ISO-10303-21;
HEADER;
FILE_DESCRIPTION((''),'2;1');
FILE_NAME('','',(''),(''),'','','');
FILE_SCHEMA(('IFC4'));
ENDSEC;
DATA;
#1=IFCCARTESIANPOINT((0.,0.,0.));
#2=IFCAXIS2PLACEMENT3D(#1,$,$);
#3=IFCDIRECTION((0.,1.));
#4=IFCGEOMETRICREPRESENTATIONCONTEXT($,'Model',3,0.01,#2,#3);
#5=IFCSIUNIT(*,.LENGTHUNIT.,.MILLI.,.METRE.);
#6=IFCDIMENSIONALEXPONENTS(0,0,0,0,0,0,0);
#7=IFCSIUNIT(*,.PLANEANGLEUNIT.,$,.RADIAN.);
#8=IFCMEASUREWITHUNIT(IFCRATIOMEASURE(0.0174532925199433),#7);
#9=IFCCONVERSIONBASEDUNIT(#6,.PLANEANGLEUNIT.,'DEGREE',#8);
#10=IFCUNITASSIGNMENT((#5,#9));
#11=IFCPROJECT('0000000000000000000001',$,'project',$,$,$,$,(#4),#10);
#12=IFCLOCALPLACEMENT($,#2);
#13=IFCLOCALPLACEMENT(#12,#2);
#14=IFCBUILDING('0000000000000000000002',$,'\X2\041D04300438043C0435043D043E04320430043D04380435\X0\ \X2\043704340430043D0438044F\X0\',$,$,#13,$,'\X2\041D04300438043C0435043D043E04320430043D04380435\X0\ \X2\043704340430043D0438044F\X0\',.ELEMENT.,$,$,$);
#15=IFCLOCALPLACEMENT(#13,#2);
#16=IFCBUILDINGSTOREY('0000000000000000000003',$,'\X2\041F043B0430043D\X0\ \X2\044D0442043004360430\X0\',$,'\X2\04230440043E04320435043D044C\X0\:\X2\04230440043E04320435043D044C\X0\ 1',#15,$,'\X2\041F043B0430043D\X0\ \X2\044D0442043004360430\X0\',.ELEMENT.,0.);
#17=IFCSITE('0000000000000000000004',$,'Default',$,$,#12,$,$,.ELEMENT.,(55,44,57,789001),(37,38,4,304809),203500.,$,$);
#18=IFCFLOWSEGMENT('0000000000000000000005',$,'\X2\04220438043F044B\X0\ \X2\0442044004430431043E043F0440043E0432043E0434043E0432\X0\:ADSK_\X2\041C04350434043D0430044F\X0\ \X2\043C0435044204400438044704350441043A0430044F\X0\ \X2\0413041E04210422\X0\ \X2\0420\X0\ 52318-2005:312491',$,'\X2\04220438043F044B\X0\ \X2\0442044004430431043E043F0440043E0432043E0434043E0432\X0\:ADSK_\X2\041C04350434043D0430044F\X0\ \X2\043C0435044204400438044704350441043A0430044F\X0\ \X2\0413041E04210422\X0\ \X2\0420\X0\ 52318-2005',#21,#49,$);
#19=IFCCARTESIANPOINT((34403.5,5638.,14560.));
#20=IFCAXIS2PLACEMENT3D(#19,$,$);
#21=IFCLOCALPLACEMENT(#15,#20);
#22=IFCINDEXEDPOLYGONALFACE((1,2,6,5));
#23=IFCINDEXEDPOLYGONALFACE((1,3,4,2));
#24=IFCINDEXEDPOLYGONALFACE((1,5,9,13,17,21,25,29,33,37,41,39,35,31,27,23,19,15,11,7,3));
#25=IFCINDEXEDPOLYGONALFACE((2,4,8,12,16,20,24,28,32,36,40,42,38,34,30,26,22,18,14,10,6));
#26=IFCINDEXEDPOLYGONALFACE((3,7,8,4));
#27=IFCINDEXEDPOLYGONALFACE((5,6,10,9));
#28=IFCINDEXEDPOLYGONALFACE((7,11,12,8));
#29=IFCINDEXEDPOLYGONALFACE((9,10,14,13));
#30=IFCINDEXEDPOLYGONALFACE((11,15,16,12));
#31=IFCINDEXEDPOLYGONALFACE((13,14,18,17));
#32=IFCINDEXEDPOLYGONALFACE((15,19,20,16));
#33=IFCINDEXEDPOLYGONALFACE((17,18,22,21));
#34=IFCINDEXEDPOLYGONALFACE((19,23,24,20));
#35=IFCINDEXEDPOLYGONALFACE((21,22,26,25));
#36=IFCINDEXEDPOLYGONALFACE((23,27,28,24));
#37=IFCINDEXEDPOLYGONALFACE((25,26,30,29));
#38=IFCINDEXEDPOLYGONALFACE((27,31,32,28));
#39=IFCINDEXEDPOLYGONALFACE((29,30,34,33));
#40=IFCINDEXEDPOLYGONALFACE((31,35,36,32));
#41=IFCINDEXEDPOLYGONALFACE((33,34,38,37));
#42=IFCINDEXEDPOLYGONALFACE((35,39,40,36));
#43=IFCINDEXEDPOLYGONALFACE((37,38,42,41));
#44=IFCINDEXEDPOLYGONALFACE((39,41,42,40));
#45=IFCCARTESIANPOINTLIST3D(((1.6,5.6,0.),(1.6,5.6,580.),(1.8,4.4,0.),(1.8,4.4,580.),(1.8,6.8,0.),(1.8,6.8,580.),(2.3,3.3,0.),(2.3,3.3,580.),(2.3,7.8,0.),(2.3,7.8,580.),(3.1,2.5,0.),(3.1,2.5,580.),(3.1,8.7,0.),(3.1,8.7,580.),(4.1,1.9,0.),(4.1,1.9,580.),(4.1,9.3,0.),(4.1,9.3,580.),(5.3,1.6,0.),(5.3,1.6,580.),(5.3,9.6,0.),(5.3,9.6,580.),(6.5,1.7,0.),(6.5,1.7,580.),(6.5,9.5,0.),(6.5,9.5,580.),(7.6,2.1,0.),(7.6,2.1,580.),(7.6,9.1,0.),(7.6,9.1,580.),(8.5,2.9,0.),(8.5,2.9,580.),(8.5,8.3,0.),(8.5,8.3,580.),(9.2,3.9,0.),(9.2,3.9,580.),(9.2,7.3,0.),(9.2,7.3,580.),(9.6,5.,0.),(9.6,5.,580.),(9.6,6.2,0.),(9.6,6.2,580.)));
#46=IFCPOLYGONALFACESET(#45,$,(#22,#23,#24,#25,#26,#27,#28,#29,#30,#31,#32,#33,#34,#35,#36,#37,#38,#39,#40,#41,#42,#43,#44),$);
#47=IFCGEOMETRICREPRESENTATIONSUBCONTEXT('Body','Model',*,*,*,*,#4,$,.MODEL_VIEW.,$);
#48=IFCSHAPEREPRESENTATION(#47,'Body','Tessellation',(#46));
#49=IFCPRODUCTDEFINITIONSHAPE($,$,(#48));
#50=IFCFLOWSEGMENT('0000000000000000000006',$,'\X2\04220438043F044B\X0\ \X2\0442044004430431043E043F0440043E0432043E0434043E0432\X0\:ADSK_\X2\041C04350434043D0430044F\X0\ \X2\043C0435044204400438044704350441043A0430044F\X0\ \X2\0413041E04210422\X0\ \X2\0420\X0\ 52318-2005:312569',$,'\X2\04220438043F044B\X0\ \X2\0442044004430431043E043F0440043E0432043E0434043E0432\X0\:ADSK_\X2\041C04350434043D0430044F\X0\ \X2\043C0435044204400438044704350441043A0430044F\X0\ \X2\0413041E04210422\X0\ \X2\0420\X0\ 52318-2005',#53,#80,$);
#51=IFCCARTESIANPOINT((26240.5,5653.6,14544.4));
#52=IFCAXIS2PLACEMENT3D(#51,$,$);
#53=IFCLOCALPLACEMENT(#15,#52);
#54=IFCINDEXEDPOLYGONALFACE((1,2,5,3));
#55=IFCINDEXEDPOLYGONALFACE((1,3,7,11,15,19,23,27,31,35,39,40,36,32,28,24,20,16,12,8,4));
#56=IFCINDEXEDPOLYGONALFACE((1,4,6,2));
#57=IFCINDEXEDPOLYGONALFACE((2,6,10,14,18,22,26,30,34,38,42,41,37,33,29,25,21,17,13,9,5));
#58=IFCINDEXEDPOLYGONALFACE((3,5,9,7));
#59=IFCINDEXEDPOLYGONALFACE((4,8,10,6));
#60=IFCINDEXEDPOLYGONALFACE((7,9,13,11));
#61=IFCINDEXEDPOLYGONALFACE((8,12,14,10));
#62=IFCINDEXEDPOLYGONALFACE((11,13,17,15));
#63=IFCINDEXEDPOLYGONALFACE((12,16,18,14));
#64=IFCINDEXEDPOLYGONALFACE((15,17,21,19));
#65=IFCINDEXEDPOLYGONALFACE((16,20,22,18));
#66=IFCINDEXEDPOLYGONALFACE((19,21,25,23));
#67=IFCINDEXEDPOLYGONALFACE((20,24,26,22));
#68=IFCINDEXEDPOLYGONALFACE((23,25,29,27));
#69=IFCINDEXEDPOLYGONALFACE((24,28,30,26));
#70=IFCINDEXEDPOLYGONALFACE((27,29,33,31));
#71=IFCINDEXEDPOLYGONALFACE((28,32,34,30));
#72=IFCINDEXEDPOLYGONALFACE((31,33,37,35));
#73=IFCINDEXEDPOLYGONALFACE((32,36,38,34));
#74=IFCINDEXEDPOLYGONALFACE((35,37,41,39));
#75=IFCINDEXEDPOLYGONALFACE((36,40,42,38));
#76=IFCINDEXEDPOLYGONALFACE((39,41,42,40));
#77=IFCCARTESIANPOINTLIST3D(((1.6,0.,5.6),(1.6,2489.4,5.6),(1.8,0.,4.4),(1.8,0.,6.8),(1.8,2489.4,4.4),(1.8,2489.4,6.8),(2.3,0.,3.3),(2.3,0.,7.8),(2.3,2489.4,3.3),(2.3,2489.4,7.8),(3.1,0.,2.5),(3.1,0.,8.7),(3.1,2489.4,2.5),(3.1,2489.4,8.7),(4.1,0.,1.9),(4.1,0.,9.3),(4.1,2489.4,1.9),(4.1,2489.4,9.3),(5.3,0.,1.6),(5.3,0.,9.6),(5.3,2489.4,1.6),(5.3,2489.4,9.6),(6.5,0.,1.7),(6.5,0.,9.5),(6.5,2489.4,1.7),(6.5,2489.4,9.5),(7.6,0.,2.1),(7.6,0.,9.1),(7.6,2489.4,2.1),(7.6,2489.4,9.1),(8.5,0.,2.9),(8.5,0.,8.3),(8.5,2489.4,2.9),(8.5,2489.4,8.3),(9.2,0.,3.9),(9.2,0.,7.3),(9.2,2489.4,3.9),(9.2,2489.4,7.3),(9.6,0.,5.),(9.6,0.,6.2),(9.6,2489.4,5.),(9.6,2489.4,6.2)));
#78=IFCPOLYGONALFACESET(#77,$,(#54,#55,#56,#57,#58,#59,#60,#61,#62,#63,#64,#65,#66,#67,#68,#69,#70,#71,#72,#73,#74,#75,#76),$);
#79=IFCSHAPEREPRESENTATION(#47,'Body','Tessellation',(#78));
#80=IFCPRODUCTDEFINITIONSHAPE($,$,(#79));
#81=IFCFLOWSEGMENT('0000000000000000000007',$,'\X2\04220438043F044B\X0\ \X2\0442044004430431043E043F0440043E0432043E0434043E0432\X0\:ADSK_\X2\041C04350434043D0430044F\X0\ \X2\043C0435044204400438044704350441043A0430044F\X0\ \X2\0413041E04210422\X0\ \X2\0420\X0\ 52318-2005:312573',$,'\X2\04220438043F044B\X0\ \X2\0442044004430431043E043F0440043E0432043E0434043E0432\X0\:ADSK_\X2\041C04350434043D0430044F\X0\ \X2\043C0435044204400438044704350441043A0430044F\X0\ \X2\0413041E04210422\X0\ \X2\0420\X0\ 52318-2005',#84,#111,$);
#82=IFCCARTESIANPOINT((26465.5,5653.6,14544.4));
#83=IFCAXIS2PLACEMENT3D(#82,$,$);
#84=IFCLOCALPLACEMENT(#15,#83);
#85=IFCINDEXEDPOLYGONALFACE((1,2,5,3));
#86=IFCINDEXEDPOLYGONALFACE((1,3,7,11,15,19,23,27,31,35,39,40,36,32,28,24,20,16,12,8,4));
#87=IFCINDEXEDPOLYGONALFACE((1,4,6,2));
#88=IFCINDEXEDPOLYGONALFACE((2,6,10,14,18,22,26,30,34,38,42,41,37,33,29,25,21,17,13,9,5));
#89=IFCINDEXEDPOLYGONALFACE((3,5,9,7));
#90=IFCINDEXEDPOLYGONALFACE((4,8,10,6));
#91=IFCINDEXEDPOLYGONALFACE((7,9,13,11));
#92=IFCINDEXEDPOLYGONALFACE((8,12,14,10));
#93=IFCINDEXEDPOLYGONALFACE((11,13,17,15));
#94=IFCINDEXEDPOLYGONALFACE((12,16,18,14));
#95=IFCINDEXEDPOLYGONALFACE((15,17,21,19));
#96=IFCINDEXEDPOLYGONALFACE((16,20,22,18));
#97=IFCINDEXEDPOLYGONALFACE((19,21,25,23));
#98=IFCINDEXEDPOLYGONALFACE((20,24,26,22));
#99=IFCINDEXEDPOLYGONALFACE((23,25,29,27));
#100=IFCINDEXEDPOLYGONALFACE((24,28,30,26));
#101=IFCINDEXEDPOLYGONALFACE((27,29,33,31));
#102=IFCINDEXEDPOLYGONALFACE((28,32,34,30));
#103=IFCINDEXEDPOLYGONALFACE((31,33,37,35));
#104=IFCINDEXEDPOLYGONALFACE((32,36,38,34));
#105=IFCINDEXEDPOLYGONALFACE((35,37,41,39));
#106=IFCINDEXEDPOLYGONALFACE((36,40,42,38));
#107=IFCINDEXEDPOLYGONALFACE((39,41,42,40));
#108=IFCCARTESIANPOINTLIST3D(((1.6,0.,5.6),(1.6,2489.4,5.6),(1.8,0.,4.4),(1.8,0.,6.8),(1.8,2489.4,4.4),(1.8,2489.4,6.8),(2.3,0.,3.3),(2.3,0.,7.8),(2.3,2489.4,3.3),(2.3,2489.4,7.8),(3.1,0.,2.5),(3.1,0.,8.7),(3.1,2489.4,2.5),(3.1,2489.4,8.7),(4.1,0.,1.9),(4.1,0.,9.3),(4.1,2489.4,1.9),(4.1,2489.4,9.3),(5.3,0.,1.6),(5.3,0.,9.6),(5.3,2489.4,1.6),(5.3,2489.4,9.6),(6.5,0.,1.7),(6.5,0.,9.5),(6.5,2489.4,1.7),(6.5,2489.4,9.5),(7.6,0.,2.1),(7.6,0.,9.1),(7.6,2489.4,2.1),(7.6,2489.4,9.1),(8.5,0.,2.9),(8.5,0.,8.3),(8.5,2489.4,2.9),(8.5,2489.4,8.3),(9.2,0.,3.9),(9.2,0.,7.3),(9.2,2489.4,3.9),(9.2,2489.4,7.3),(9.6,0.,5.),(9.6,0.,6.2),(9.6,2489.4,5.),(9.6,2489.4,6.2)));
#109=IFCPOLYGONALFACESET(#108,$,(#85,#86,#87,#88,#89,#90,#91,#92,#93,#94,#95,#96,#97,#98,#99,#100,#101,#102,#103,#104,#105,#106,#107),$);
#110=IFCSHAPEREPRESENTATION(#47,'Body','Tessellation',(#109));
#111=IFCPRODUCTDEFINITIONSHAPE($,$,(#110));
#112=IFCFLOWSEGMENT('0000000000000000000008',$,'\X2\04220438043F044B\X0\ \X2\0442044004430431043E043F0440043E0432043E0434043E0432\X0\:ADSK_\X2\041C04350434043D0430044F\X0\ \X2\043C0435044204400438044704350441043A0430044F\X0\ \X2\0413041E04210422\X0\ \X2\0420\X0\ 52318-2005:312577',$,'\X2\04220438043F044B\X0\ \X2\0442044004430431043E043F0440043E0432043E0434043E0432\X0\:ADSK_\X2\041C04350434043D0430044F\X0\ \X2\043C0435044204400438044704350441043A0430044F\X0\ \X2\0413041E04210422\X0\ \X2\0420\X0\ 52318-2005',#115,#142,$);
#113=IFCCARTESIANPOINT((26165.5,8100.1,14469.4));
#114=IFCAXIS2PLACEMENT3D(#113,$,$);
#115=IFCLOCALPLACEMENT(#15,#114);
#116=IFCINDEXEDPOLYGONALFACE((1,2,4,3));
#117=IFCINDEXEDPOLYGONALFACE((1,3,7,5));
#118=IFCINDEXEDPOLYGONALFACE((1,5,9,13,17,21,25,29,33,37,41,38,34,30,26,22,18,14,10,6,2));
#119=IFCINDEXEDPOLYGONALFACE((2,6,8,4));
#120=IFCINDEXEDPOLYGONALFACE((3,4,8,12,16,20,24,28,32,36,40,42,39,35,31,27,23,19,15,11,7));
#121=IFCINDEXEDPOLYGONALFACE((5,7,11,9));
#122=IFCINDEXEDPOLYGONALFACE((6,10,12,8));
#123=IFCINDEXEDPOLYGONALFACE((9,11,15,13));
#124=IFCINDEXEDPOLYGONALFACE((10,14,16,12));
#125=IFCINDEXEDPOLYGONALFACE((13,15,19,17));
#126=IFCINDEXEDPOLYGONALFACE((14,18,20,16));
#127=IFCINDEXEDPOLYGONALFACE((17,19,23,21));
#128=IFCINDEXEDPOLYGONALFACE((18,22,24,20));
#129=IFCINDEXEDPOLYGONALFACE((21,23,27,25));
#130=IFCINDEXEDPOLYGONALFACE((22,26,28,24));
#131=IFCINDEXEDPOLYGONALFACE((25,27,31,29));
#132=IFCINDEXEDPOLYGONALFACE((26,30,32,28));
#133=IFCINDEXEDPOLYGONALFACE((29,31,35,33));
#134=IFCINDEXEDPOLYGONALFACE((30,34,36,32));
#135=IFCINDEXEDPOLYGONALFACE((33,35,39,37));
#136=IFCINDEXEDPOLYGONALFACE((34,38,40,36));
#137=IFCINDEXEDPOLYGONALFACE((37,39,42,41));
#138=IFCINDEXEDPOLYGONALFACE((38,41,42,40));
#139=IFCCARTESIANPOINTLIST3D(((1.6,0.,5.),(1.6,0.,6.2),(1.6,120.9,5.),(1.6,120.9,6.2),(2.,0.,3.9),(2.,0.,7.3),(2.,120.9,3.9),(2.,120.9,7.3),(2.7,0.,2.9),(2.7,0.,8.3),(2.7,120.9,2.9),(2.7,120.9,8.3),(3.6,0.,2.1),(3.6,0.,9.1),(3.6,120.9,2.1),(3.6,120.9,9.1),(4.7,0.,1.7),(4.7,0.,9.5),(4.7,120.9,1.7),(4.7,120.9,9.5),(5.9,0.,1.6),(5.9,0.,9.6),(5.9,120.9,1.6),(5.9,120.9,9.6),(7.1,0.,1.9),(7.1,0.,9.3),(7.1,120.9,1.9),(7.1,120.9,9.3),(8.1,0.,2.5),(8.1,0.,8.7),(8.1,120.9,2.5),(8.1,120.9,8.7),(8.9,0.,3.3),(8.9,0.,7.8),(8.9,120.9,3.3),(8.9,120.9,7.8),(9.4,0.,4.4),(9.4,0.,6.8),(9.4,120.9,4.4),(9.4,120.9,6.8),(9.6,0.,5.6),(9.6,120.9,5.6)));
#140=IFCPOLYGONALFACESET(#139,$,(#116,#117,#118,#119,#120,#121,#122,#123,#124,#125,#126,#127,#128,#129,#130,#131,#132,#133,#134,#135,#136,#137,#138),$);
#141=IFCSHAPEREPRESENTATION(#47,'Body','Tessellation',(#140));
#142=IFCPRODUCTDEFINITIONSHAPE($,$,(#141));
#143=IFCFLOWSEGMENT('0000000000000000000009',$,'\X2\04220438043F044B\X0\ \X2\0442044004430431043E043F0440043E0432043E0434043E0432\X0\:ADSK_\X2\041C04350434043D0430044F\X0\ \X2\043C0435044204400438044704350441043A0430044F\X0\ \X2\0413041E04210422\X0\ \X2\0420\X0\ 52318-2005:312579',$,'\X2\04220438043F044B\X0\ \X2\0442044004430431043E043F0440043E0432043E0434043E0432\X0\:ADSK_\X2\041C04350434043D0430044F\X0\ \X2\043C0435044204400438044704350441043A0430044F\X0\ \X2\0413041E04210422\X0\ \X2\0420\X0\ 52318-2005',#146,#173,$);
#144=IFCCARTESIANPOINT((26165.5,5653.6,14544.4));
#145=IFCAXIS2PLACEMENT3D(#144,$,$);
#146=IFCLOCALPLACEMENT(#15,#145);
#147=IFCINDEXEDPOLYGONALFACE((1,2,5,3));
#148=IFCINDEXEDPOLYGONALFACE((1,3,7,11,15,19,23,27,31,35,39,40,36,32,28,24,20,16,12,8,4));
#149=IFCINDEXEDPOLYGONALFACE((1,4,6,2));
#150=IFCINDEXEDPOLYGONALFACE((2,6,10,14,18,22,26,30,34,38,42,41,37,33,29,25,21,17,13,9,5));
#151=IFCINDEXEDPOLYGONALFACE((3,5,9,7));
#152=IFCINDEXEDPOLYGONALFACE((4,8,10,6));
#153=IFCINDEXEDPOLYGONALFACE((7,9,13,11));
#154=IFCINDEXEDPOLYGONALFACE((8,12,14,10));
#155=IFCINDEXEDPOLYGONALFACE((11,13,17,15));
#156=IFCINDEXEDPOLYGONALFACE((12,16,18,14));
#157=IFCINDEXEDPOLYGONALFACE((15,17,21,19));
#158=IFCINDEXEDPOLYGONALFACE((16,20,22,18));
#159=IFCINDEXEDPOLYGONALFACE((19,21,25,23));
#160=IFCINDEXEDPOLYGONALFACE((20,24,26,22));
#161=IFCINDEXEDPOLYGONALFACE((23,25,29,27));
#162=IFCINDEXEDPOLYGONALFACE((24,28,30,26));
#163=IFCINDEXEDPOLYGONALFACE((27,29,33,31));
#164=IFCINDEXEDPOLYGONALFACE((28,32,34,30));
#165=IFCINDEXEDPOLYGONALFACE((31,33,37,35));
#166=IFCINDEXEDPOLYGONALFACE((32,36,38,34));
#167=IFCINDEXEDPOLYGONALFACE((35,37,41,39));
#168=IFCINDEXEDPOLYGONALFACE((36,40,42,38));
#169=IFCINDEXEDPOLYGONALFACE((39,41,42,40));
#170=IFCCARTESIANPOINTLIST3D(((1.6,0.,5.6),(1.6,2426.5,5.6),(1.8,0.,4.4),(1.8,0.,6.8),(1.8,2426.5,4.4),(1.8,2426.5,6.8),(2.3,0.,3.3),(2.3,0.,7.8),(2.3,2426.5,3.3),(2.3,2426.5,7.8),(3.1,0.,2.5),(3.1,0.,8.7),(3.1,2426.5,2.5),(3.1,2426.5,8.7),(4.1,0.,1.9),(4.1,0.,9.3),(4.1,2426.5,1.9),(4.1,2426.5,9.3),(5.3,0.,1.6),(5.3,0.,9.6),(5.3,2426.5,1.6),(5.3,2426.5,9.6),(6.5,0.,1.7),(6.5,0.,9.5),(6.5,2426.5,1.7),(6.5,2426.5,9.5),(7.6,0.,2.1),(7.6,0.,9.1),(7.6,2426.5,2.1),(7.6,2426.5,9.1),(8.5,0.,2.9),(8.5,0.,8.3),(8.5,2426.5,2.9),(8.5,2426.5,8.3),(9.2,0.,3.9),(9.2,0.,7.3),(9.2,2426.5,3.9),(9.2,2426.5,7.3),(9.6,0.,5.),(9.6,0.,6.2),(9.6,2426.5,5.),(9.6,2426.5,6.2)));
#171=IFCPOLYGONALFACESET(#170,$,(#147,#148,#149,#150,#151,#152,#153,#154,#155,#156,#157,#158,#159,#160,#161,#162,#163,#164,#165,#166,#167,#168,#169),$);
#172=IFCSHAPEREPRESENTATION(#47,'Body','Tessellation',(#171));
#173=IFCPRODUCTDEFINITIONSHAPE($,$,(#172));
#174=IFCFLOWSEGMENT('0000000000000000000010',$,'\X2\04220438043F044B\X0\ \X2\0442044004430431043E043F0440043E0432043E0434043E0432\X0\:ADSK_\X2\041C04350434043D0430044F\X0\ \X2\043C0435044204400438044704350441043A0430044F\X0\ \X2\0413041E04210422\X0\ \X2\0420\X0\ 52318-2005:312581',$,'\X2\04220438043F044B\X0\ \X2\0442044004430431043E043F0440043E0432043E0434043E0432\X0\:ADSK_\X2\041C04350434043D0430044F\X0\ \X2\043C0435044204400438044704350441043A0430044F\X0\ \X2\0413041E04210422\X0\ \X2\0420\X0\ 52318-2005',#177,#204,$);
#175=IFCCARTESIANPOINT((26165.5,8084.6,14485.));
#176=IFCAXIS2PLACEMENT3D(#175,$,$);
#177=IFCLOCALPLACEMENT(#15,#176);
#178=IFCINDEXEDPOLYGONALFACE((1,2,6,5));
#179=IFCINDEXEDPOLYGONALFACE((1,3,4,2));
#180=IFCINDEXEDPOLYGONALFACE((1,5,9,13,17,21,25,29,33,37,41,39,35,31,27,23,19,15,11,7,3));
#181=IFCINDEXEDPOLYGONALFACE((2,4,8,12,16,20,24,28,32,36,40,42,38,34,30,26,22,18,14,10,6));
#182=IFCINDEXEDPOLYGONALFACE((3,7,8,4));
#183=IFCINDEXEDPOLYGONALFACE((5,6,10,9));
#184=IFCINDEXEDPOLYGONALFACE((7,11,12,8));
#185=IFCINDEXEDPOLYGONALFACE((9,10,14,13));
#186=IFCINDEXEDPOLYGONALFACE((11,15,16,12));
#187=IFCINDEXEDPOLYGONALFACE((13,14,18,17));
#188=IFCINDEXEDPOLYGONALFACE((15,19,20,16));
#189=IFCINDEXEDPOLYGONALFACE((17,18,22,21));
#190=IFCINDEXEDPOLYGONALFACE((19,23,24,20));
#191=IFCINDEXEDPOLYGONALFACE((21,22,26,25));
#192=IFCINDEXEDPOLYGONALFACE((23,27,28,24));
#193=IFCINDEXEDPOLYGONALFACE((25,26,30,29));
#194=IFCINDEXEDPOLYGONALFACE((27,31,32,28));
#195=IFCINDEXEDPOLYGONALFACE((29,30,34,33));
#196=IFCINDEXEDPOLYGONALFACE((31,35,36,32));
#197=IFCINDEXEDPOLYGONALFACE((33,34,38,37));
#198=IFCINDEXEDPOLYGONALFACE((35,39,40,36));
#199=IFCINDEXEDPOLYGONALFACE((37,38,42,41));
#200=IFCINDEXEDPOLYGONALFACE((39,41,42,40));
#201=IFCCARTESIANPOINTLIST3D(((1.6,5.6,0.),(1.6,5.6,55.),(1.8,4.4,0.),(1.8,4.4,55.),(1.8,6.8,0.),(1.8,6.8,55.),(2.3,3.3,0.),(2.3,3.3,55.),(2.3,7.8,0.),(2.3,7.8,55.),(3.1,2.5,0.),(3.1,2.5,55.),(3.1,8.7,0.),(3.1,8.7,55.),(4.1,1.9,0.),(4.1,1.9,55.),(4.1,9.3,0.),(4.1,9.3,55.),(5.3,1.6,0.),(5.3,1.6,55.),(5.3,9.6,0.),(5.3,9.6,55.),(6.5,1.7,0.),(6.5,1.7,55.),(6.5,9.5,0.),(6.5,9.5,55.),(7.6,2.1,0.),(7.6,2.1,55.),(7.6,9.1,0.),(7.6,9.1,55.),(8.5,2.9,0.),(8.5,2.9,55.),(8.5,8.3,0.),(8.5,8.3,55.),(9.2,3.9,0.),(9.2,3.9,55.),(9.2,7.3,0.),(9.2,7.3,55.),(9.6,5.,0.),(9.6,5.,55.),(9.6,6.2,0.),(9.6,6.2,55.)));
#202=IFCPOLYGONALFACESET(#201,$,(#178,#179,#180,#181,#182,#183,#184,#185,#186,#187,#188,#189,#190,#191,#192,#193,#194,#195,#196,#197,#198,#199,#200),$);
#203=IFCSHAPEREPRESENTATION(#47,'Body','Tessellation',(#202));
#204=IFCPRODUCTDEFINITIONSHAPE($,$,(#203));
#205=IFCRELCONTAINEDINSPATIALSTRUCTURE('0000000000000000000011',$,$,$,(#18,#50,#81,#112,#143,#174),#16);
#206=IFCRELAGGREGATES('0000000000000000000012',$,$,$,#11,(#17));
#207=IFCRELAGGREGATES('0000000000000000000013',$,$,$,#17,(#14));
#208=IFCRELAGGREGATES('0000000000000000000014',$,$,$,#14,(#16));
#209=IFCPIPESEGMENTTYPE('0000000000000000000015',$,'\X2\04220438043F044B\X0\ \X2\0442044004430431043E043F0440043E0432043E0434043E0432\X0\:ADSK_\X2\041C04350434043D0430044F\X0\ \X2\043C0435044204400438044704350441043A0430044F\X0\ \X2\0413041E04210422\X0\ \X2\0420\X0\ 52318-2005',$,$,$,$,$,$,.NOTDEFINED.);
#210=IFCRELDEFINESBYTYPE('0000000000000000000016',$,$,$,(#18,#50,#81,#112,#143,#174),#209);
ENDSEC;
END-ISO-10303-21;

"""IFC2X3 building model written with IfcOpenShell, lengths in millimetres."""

from ifc_helpers import new_model, entity, si_unit, converted_unit, direction, frame, frame_2d, origin, origin_2d_with_axis, place, context, subcontext, project, spatial, circle, extrude, type_object, element, save


model = new_model("IFC2X3")

# Units and contexts
model_context = context("Model", 3, precision=0.01, world=origin(), true_north=direction((0.0, 1.0)))
body_context = subcontext(model_context, "Body", "Model", "MODEL_VIEW")
ifc_project = project(units=[si_unit("LENGTHUNIT", "METRE", prefix="MILLI"), converted_unit("PLANEANGLEUNIT", "DEGREE", entity("IfcRatioMeasure", 0.0174532925199433), si_unit("PLANEANGLEUNIT", "RADIAN"), dimensions=[0, 0, 0, 0, 0, 0, 0])], contexts=[model_context])

# Site, building, storey
site_placement = place(None, frame((0.0, 0.0, 0.0)))
site = spatial("IfcSite", under=ifc_project, at=site_placement, Name="Default", CompositionType="ELEMENT", RefLatitude=(55, 44, 57, 789001), RefLongitude=(37, 38, 4, 304809), RefElevation=203500.0)
building_placement = place(site_placement, origin())
building = spatial("IfcBuilding", under=site, at=building_placement, Name="Наименование здания", LongName="Наименование здания", CompositionType="ELEMENT")
storey_placement = place(building_placement, origin())
storey = spatial("IfcBuildingStorey", under=building, at=storey_placement, Name="План этажа", ObjectType="Уровень:Уровень 1", LongName="План этажа", CompositionType="ELEMENT", Elevation=0.0)

# Flow segments
pipe_segment_type = type_object("IfcPipeSegmentType", Name="Типы трубопроводов:ADSK_Медная метрическая ГОСТ Р 52318-2005", PredefinedType="NOTDEFINED")
flow_segment_1_placement = place(storey_placement, frame((34403.5, 5638.0, 14560.0)))
element("IfcFlowSegment", 1, at=flow_segment_1_placement, inside=storey, type_object=pipe_segment_type, Name="Типы трубопроводов:ADSK_Медная метрическая ГОСТ Р 52318-2005:312491", ObjectType="Типы трубопроводов:ADSK_Медная метрическая ГОСТ Р 52318-2005", context=body_context, shape_type="SweptSolid", body=[
    extrude(circle(Radius=4.0, at=origin_2d_with_axis()), frame((5.6, 5.6, 0.0), z_axis=(0.0, 0.0, 1.0), x_axis=(-1.0, 0.0, 0.0)), (0.0, 0.0, 1.0), 580.0),
])
flow_segment_2_placement = place(storey_placement, frame((26240.5, 5653.6, 14544.4)))
element("IfcFlowSegment", 2, at=flow_segment_2_placement, inside=storey, type_object=pipe_segment_type, Name="Типы трубопроводов:ADSK_Медная метрическая ГОСТ Р 52318-2005:312569", ObjectType="Типы трубопроводов:ADSK_Медная метрическая ГОСТ Р 52318-2005", context=body_context, shape_type="SweptSolid", body=[
    extrude(circle(Radius=4.0, at=frame_2d((0.0, 0.0), x_axis=(1.0, 0.0))), frame((5.6, 0.0, 5.6), z_axis=(0.0, 1.0, 0.0), x_axis=(-1.0, 0.0, 0.0)), (0.0, 0.0, 1.0), 2489.4),
])
flow_segment_3_placement = place(storey_placement, frame((26465.5, 5653.6, 14544.4)))
element("IfcFlowSegment", 3, at=flow_segment_3_placement, inside=storey, type_object=pipe_segment_type, Name="Типы трубопроводов:ADSK_Медная метрическая ГОСТ Р 52318-2005:312573", ObjectType="Типы трубопроводов:ADSK_Медная метрическая ГОСТ Р 52318-2005", context=body_context, shape_type="SweptSolid", body=[
    extrude(circle(Radius=4.0, at=frame_2d((0.0, 0.0), x_axis=(1.0, 0.0))), frame((5.6, 0.0, 5.6), z_axis=(0.0, 1.0, 0.0), x_axis=(-1.0, 0.0, 0.0)), (0.0, 0.0, 1.0), 2489.4),
])
flow_segment_4_placement = place(storey_placement, frame((26165.5, 8100.1, 14469.4)))
element("IfcFlowSegment", 4, at=flow_segment_4_placement, inside=storey, type_object=pipe_segment_type, Name="Типы трубопроводов:ADSK_Медная метрическая ГОСТ Р 52318-2005:312577", ObjectType="Типы трубопроводов:ADSK_Медная метрическая ГОСТ Р 52318-2005", context=body_context, shape_type="SweptSolid", body=[
    extrude(circle(Radius=4.0, at=origin_2d_with_axis()), frame((5.6, 0.0, 5.6), z_axis=(0.0, 1.0, 0.0), x_axis=(1.0, 0.0, 0.0)), (0.0, 0.0, 1.0), 120.9),
])
flow_segment_5_placement = place(storey_placement, frame((26165.5, 5653.6, 14544.4)))
element("IfcFlowSegment", 5, at=flow_segment_5_placement, inside=storey, type_object=pipe_segment_type, Name="Типы трубопроводов:ADSK_Медная метрическая ГОСТ Р 52318-2005:312579", ObjectType="Типы трубопроводов:ADSK_Медная метрическая ГОСТ Р 52318-2005", context=body_context, shape_type="SweptSolid", body=[
    extrude(circle(Radius=4.0, at=origin_2d_with_axis()), frame((5.6, 0.0, 5.6), z_axis=(0.0, 1.0, 0.0), x_axis=(-1.0, 0.0, 0.0)), (0.0, 0.0, 1.0), 2426.5),
])
flow_segment_6_placement = place(storey_placement, frame((26165.5, 8084.6, 14485.0)))
element("IfcFlowSegment", 6, at=flow_segment_6_placement, inside=storey, type_object=pipe_segment_type, Name="Типы трубопроводов:ADSK_Медная метрическая ГОСТ Р 52318-2005:312581", ObjectType="Типы трубопроводов:ADSK_Медная метрическая ГОСТ Р 52318-2005", context=body_context, shape_type="SweptSolid", body=[
    extrude(circle(Radius=4.0, at=origin_2d_with_axis()), frame((5.6, 5.6, 0.0), z_axis=(0.0, 0.0, 1.0), x_axis=(-1.0, 0.0, 0.0)), (0.0, 0.0, 1.0), 55.0),
])

save(model, "model.ifc")
